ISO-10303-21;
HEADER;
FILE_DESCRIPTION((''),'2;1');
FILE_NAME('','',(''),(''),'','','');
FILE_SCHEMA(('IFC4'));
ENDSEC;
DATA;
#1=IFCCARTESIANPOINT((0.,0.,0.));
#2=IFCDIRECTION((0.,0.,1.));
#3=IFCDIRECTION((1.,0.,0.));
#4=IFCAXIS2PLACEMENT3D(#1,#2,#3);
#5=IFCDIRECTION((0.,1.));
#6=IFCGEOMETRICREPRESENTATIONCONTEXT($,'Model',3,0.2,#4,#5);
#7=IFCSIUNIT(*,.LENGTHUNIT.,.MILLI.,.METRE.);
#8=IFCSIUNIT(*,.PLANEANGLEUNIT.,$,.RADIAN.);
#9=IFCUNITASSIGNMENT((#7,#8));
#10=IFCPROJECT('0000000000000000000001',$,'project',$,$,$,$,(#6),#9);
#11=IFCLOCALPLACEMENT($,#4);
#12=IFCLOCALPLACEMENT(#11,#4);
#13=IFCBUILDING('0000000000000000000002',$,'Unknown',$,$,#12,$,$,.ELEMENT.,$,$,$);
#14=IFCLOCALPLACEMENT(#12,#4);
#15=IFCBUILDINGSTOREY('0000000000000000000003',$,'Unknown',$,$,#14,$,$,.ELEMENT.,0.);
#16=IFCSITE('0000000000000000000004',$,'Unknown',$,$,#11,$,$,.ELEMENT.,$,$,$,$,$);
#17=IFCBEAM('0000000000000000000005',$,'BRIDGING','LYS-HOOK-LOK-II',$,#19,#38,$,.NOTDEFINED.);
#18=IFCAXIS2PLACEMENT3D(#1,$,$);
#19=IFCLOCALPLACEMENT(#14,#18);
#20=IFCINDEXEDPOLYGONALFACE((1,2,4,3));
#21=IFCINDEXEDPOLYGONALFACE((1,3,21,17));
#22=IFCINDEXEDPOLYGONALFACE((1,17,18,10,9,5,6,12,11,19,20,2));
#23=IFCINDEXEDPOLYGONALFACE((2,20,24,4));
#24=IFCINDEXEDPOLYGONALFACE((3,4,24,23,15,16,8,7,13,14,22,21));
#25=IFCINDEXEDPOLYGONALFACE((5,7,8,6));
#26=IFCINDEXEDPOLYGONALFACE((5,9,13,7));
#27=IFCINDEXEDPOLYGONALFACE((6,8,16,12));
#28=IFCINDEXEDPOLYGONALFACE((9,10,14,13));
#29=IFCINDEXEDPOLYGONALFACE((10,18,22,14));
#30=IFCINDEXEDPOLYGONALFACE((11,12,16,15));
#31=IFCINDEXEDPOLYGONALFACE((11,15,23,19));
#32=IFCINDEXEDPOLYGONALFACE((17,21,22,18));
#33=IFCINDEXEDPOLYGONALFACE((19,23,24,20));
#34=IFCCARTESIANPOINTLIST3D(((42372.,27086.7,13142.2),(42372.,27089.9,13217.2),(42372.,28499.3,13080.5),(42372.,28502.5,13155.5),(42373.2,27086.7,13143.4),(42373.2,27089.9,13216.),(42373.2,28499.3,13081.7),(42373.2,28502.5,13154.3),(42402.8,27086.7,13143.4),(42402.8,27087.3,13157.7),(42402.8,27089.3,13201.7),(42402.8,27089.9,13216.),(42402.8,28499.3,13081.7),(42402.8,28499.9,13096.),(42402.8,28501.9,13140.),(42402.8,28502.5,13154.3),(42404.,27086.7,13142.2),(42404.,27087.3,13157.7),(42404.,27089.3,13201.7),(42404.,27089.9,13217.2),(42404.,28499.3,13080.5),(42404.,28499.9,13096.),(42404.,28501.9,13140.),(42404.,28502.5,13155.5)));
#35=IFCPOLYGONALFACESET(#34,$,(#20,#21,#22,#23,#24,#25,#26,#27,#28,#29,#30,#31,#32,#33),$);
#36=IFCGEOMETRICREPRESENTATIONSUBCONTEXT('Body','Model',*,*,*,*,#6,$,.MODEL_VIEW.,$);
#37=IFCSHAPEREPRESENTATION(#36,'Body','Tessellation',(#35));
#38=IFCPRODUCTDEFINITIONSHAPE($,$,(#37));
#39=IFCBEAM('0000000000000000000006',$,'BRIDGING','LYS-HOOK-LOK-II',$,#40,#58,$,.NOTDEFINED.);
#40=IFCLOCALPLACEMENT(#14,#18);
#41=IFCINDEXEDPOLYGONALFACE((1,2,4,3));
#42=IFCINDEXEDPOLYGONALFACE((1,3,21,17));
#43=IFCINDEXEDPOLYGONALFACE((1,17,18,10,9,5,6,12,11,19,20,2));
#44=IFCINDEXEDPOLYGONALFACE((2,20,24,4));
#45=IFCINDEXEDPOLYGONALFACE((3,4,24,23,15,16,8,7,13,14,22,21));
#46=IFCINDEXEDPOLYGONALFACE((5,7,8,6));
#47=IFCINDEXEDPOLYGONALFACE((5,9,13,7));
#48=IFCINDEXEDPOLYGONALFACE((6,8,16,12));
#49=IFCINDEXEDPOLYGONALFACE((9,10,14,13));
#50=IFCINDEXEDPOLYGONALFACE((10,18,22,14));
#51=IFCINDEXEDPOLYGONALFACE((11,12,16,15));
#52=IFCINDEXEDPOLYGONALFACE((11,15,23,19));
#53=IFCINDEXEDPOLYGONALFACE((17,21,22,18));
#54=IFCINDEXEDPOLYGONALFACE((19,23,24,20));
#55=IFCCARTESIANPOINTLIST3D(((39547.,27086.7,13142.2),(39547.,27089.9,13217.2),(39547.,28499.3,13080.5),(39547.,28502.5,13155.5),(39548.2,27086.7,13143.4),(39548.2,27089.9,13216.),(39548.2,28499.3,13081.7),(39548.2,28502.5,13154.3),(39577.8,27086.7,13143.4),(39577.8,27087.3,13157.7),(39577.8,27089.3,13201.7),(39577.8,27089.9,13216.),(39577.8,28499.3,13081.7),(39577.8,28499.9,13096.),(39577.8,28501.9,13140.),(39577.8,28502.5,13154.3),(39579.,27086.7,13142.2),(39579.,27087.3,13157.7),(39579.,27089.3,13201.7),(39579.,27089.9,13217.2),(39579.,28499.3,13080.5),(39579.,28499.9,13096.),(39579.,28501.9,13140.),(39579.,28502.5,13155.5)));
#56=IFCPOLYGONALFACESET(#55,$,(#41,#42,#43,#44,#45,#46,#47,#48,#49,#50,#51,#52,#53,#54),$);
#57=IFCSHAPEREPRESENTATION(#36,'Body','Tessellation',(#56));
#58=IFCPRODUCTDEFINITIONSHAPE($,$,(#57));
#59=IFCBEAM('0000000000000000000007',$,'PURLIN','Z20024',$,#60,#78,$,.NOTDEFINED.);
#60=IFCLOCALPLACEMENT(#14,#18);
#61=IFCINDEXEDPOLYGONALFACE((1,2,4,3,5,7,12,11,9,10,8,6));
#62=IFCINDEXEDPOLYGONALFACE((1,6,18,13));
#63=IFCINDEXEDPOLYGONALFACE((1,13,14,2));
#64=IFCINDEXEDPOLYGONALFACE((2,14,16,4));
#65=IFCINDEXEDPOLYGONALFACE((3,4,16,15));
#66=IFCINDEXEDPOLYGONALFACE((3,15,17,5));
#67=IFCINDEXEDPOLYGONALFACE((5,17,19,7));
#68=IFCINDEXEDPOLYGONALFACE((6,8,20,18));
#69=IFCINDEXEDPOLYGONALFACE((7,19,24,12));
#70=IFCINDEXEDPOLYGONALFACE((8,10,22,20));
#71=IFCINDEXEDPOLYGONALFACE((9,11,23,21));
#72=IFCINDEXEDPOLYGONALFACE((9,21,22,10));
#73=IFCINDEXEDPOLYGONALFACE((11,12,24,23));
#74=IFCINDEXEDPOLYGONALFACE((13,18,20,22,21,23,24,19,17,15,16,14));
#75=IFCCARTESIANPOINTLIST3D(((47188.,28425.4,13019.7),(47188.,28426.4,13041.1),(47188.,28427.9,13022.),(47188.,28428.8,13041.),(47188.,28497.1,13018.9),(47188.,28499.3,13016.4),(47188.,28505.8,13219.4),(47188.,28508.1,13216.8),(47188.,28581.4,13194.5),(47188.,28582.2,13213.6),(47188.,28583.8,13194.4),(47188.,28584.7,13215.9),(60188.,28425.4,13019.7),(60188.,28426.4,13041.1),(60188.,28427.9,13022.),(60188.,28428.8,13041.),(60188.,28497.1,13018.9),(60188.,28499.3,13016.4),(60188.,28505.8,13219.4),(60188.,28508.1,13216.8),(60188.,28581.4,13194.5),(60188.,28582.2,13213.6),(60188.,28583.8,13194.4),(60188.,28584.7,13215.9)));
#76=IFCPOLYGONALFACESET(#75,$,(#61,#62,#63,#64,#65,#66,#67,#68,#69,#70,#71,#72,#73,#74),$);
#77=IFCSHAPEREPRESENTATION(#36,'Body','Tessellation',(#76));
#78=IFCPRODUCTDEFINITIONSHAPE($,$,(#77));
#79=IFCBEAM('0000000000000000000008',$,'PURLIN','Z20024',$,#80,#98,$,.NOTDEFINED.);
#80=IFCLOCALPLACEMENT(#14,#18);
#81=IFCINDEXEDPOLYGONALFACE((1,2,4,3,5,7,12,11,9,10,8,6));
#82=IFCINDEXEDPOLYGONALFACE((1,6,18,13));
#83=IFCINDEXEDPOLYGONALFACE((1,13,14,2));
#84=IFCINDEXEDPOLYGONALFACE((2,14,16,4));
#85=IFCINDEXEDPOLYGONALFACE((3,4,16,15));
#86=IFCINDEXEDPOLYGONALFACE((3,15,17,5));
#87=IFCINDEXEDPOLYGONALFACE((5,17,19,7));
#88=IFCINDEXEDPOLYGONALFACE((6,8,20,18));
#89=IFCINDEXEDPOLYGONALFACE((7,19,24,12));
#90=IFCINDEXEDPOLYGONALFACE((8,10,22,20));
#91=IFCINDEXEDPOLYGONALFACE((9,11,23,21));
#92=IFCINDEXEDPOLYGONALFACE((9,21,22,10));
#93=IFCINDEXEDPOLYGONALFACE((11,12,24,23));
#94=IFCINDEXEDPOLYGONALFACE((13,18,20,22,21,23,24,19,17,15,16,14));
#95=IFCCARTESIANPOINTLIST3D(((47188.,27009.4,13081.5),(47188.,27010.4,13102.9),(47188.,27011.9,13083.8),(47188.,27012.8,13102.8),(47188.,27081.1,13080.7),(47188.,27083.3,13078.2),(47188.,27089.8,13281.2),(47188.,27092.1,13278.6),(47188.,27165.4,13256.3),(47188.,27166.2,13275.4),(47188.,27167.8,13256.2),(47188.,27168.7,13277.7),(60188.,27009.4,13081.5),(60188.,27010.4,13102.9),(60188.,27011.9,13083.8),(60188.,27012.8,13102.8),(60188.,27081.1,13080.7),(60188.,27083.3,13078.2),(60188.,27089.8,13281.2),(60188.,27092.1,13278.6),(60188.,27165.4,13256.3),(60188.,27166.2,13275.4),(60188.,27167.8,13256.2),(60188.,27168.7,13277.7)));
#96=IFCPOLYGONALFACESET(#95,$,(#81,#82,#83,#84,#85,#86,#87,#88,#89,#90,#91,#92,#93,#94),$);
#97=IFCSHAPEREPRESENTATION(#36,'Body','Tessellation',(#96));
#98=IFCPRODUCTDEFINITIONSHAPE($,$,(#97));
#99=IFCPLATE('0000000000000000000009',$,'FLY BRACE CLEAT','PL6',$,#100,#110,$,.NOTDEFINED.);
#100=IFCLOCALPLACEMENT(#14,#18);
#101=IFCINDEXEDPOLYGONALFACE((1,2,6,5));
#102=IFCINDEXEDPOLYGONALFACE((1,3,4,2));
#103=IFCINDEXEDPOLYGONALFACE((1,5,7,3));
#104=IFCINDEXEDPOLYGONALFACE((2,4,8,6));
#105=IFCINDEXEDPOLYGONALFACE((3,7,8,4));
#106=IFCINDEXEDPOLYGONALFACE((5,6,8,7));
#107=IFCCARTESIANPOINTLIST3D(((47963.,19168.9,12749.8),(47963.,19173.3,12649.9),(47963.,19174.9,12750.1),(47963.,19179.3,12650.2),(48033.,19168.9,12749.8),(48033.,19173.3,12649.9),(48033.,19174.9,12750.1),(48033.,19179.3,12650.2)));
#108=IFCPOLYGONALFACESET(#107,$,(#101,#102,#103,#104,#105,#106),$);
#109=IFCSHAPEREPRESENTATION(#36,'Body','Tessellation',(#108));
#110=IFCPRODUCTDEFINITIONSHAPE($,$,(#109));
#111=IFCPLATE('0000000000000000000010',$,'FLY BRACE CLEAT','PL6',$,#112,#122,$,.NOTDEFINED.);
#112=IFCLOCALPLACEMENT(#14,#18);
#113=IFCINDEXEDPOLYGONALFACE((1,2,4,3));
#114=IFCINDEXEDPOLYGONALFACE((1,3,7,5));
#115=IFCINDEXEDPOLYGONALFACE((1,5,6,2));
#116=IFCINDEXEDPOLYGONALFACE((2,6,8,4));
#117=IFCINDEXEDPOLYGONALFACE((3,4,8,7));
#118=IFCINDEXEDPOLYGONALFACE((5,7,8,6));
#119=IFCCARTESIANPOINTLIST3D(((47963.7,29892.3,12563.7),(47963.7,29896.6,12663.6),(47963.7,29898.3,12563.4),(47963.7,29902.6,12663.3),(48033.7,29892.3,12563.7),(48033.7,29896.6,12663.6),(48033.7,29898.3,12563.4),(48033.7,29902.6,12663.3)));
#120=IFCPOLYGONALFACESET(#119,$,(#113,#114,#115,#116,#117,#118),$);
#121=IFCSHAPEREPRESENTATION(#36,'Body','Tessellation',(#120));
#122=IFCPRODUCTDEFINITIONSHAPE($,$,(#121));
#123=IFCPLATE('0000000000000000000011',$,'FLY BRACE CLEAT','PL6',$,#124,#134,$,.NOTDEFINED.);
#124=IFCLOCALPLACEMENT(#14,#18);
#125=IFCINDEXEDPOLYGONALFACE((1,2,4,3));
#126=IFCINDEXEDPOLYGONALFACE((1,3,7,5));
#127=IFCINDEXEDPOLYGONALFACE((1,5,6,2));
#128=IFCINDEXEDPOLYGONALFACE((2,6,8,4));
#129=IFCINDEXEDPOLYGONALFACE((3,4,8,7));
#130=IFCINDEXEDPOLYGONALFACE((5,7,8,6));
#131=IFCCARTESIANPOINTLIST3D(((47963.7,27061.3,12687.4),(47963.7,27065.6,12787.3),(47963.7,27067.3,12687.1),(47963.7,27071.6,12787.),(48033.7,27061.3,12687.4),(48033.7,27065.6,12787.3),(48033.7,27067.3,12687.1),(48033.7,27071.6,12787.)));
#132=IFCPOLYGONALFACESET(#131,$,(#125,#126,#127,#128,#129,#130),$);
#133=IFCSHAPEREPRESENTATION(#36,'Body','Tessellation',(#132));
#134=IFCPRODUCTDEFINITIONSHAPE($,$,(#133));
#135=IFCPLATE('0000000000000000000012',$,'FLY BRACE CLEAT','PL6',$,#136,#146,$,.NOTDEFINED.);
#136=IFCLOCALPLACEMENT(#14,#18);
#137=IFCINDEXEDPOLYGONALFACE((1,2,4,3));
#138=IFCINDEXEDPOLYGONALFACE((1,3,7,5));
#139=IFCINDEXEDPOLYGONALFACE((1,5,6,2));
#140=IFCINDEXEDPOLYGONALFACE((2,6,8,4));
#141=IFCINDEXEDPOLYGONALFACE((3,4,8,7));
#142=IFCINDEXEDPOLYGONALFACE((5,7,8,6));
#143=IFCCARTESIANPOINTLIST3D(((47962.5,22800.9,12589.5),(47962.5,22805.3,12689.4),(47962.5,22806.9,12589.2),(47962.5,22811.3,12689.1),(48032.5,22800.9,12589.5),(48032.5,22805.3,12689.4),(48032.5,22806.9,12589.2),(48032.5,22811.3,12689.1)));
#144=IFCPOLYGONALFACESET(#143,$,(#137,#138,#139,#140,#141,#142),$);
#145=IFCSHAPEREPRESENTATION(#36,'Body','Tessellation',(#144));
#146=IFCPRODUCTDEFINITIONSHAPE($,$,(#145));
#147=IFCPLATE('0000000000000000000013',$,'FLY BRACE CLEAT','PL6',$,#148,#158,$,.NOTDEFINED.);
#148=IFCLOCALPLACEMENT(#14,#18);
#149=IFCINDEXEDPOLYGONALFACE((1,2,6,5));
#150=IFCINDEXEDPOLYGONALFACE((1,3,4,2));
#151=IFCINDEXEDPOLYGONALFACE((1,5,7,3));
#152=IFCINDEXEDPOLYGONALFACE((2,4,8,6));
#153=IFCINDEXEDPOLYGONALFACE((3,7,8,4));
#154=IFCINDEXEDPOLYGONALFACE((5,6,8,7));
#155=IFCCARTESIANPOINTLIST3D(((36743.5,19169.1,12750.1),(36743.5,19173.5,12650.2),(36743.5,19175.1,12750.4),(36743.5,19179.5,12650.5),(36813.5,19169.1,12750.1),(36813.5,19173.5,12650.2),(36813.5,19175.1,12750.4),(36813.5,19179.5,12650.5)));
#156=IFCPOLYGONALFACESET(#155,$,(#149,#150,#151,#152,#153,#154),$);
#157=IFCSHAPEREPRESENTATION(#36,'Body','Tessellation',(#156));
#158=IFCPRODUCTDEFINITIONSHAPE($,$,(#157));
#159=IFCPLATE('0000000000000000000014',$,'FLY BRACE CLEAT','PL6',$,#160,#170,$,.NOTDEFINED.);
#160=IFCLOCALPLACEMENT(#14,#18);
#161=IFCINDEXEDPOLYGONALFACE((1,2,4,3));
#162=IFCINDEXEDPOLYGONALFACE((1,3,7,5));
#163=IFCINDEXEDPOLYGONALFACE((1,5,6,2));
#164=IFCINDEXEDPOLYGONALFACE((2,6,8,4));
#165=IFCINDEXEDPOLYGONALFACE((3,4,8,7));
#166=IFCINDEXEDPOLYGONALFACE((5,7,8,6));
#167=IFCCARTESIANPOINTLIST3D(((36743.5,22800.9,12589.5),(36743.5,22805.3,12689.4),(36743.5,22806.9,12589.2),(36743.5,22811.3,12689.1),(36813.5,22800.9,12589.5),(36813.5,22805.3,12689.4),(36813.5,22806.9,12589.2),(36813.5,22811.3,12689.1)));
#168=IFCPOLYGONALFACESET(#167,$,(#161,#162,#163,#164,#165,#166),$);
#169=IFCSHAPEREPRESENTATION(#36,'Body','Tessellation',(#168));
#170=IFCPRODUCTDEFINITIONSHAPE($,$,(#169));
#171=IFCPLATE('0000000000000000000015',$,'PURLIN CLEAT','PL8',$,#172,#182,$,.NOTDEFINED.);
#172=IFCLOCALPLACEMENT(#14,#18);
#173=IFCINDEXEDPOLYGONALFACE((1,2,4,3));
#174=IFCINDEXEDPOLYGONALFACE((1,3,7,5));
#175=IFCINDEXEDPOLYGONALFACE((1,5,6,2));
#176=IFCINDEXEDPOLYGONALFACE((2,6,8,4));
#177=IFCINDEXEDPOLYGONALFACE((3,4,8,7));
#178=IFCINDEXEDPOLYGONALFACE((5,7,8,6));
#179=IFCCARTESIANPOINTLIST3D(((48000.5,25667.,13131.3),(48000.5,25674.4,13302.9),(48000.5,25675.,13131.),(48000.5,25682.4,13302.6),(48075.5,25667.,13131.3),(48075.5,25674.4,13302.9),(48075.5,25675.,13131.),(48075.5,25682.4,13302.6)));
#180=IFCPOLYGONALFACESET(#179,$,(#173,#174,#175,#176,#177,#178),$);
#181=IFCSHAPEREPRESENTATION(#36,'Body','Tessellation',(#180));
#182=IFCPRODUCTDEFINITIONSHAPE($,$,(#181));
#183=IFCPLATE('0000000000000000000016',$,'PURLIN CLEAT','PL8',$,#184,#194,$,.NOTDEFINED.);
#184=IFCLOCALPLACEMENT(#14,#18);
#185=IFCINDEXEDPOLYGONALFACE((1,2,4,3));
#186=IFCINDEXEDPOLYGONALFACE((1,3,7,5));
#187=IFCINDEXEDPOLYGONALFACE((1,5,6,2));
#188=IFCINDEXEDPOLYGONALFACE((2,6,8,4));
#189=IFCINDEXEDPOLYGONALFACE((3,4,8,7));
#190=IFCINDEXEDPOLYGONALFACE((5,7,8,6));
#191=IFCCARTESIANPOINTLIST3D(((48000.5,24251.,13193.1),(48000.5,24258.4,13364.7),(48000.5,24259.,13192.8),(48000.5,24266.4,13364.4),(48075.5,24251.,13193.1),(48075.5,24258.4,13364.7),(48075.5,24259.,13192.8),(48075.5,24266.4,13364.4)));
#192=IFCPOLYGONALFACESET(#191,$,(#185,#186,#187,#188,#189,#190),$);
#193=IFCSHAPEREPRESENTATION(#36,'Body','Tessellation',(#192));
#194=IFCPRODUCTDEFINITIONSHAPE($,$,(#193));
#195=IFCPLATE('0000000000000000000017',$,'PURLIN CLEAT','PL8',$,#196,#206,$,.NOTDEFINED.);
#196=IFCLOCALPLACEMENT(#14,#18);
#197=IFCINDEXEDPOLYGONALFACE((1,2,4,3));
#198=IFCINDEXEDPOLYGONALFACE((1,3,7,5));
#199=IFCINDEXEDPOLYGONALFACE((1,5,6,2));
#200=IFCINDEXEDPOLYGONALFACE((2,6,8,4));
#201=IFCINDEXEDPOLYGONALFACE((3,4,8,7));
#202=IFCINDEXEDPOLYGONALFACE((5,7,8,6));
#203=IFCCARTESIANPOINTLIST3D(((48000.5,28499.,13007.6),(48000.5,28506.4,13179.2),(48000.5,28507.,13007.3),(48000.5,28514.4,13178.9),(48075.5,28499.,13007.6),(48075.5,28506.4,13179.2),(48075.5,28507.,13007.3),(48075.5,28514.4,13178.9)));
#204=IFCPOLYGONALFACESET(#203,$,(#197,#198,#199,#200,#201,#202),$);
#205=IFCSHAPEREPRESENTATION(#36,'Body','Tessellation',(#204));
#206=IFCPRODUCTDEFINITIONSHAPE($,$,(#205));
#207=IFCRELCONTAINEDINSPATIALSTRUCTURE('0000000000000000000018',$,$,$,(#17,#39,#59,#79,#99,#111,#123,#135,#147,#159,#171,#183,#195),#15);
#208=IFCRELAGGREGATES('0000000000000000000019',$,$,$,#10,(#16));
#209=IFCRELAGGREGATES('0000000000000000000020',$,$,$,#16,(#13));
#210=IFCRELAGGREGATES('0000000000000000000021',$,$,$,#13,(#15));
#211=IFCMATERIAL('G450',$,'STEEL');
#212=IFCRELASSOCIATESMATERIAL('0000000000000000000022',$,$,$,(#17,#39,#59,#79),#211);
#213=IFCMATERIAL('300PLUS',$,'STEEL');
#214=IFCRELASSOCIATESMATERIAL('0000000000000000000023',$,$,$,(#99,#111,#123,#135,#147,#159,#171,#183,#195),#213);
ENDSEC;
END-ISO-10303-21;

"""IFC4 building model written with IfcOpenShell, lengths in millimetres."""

from ifc_helpers import new_model, si_unit, direction, frame, origin_with_axes, place, context, subcontext, project, spatial, line, indexed_curve, outline, extrude, material, element, save


model = new_model("IFC4")

# Units and contexts
model_context = context("Model", 3, precision=0.2, world=origin_with_axes(), true_north=direction((0.0, 1.0)))
body_context = subcontext(model_context, "Body", "Model", "MODEL_VIEW")
ifc_project = project(units=[si_unit("LENGTHUNIT", "METRE", prefix="MILLI"), si_unit("PLANEANGLEUNIT", "RADIAN")], contexts=[model_context])

# Site, building, storey
site_placement = place(None, origin_with_axes())
site = spatial("IfcSite", under=ifc_project, at=site_placement, Name="Unknown", CompositionType="ELEMENT")
building_placement = place(site_placement, origin_with_axes())
building = spatial("IfcBuilding", under=site, at=building_placement, Name="Unknown", CompositionType="ELEMENT")
storey_placement = place(building_placement, origin_with_axes())
storey = spatial("IfcBuildingStorey", under=building, at=storey_placement, Name="Unknown", CompositionType="ELEMENT", Elevation=0.0)

# Shared definitions
ifc_material_1 = material(Name="300PLUS", Category="STEEL")

# Beams
ifc_material_2 = material(Name="G450", Category="STEEL")
for number, where, z_axis, x_axis, name in (
    (1, (42388.0, 27088.3, 13179.7), (1.0, 0.0, 0.0), (0.0, 0.999047, -0.043637), "BRIDGING"),
    (2, (39563.0, 27088.3, 13179.7), (1.0, 0.0, 0.0), (0.0, 0.999047, -0.043637), "BRIDGING"),
):
    element("IfcBeam", number, at=place(storey_placement, frame(where, z_axis=z_axis, x_axis=x_axis)), inside=storey, material=ifc_material_2, Name=name, Description="LYS-HOOK-LOK-II", PredefinedType="NOTDEFINED", context=body_context, shape_type="SolidModel", body=[
        extrude(outline(indexed_curve([(16.0, -37.5), (16.0, -22.0), (14.8, -22.0), (14.8, -36.3), (-14.8, -36.3), (-14.8, 36.3), (14.8, 36.3), (14.8, 22.0), (16.0, 22.0), (16.0, 37.5), (-16.0, 37.5), (-16.0, -37.5)], segments=[line(1, 2, 3, 4, 5, 6, 7, 8, 9, 10, 11, 12, 1)])), frame((0.0, 0.0, 0.0), z_axis=(-1.0, 0.0, 0.0), x_axis=(0.0, 0.0, 1.0)), (0.0, 0.0, -1.0), 1413.9),
    ])
for number, where, z_axis, x_axis, name in (
    (3, (47188.0, 28502.6, 13117.9), (0.0, -0.999048, 0.043619), (1.0, 0.0, 0.0), "PURLIN"),
    (4, (47188.0, 27086.6, 13179.7), (0.0, -0.999048, 0.043619), (1.0, 0.0, 0.0), "PURLIN"),
):
    element("IfcBeam", number, at=place(storey_placement, frame(where, z_axis=z_axis, x_axis=x_axis)), inside=storey, material=ifc_material_2, Name=name, Description="Z20024", PredefinedType="NOTDEFINED", context=body_context, shape_type="SolidModel", body=[
        extrude(outline(indexed_curve([(72.8, -101.5), (72.8, -80.0), (70.4, -80.0), (70.4, -99.1), (1.2, -99.1), (1.2, 101.5), (-77.8, 101.5), (-77.8, 80.0), (-75.4, 80.0), (-75.4, 99.1), (-1.2, 99.1), (-1.2, -101.5)], segments=[line(1, 2, 3, 4, 5, 6, 7, 8, 9, 10, 11, 12, 1)])), frame((0.0, 0.0, 0.0), z_axis=(-1.0, 0.0, 0.0), x_axis=(0.0, 0.0, 1.0)), (0.0, 0.0, -1.0), 13000.0),
    ])

# Plates
plate_1_placement = place(storey_placement, frame((48033.0, 19176.3, 12650.0), z_axis=(0.0, 0.999031, 0.044001), x_axis=(-1.0, 0.0, 0.0)))
element("IfcPlate", 5, at=plate_1_placement, inside=storey, material=ifc_material_1, Name="FLY BRACE CLEAT", Description="PL6", PredefinedType="NOTDEFINED", context=body_context, shape_type="SolidModel", body=[
    extrude(outline(indexed_curve([(0.0, 0.0), (70.0, 0.0), (70.0, 100.0), (0.0, 100.0)], segments=[line(1, 2, 3, 4, 1)])), frame((0.0, 0.0, 3.0), z_axis=(0.0, 0.0, 1.0), x_axis=(1.0, 0.0, 0.0)), (0.0, 0.0, -1.0), 6.0),
])
for number, where, z_axis, x_axis, name in (
    (6, (47963.7, 29895.3, 12563.5), (0.0, -0.999075, 0.043003), (1.0, 0.0, 0.0), "FLY BRACE CLEAT"),
    (7, (47963.7, 27064.3, 12687.2), (0.0, -0.999075, 0.043003), (1.0, 0.0, 0.0), "FLY BRACE CLEAT"),
):
    element("IfcPlate", number, at=place(storey_placement, frame(where, z_axis=z_axis, x_axis=x_axis)), inside=storey, material=ifc_material_1, Name=name, Description="PL6", PredefinedType="NOTDEFINED", context=body_context, shape_type="SolidModel", body=[
        extrude(outline(indexed_curve([(0.0, 0.0), (70.0, 0.0), (70.0, 100.0), (0.0, 100.0)], segments=[line(1, 2, 3, 4, 1)])), frame((0.0, 0.0, 3.0), z_axis=(0.0, 0.0, 1.0), x_axis=(1.0, 0.0, 0.0)), (0.0, 0.0, -1.0), 6.0),
    ])
for number, where, z_axis, x_axis, name in (
    (8, (47962.5, 22803.9, 12589.3), (0.0, -0.999031, 0.044001), (1.0, 0.0, 0.0), "FLY BRACE CLEAT"),
    (9, (36743.5, 19172.1, 12750.2), (0.0, 0.999031, 0.044001), (1.0, 0.0, 0.0), "FLY BRACE CLEAT"),
    (10, (36743.5, 22803.9, 12589.3), (0.0, -0.999031, 0.044001), (1.0, 0.0, 0.0), "FLY BRACE CLEAT"),
):
    element("IfcPlate", number, at=place(storey_placement, frame(where, z_axis=z_axis, x_axis=x_axis)), inside=storey, material=ifc_material_1, Name=name, Description="PL6", PredefinedType="NOTDEFINED", context=body_context, shape_type="SolidModel", body=[
        extrude(outline(indexed_curve([(0.0, 0.0), (70.0, 0.0), (70.0, 100.0), (0.0, 100.0)], segments=[line(1, 2, 3, 4, 1)])), frame((0.0, 0.0, 3.0), z_axis=(0.0, 0.0, 1.0), x_axis=(1.0, 0.0, 0.0)), (0.0, 0.0, -1.0), 6.0),
    ])
for number, where, z_axis, x_axis, name in (
    (11, (48000.5, 25671.0, 13131.2), (0.0, -0.999071, 0.043084), (1.0, 0.0, 0.0), "PURLIN CLEAT"),
    (12, (48000.5, 24255.0, 13193.0), (0.0, -0.999071, 0.043084), (1.0, 0.0, 0.0), "PURLIN CLEAT"),
    (13, (48000.5, 28503.0, 13007.5), (0.0, -0.999071, 0.043084), (1.0, 0.0, 0.0), "PURLIN CLEAT"),
):
    element("IfcPlate", number, at=place(storey_placement, frame(where, z_axis=z_axis, x_axis=x_axis)), inside=storey, material=ifc_material_1, Name=name, Description="PL8", PredefinedType="NOTDEFINED", context=body_context, shape_type="SolidModel", body=[
        extrude(outline(indexed_curve([(0.0, 0.0), (75.0, 0.0), (75.0, 171.8), (0.0, 171.8)], segments=[line(1, 2, 3, 4, 1)])), frame((0.0, 0.0, 4.0), z_axis=(0.0, 0.0, 1.0), x_axis=(1.0, 0.0, 0.0)), (0.0, 0.0, -1.0), 8.0),
    ])

save(model, "model.ifc")
